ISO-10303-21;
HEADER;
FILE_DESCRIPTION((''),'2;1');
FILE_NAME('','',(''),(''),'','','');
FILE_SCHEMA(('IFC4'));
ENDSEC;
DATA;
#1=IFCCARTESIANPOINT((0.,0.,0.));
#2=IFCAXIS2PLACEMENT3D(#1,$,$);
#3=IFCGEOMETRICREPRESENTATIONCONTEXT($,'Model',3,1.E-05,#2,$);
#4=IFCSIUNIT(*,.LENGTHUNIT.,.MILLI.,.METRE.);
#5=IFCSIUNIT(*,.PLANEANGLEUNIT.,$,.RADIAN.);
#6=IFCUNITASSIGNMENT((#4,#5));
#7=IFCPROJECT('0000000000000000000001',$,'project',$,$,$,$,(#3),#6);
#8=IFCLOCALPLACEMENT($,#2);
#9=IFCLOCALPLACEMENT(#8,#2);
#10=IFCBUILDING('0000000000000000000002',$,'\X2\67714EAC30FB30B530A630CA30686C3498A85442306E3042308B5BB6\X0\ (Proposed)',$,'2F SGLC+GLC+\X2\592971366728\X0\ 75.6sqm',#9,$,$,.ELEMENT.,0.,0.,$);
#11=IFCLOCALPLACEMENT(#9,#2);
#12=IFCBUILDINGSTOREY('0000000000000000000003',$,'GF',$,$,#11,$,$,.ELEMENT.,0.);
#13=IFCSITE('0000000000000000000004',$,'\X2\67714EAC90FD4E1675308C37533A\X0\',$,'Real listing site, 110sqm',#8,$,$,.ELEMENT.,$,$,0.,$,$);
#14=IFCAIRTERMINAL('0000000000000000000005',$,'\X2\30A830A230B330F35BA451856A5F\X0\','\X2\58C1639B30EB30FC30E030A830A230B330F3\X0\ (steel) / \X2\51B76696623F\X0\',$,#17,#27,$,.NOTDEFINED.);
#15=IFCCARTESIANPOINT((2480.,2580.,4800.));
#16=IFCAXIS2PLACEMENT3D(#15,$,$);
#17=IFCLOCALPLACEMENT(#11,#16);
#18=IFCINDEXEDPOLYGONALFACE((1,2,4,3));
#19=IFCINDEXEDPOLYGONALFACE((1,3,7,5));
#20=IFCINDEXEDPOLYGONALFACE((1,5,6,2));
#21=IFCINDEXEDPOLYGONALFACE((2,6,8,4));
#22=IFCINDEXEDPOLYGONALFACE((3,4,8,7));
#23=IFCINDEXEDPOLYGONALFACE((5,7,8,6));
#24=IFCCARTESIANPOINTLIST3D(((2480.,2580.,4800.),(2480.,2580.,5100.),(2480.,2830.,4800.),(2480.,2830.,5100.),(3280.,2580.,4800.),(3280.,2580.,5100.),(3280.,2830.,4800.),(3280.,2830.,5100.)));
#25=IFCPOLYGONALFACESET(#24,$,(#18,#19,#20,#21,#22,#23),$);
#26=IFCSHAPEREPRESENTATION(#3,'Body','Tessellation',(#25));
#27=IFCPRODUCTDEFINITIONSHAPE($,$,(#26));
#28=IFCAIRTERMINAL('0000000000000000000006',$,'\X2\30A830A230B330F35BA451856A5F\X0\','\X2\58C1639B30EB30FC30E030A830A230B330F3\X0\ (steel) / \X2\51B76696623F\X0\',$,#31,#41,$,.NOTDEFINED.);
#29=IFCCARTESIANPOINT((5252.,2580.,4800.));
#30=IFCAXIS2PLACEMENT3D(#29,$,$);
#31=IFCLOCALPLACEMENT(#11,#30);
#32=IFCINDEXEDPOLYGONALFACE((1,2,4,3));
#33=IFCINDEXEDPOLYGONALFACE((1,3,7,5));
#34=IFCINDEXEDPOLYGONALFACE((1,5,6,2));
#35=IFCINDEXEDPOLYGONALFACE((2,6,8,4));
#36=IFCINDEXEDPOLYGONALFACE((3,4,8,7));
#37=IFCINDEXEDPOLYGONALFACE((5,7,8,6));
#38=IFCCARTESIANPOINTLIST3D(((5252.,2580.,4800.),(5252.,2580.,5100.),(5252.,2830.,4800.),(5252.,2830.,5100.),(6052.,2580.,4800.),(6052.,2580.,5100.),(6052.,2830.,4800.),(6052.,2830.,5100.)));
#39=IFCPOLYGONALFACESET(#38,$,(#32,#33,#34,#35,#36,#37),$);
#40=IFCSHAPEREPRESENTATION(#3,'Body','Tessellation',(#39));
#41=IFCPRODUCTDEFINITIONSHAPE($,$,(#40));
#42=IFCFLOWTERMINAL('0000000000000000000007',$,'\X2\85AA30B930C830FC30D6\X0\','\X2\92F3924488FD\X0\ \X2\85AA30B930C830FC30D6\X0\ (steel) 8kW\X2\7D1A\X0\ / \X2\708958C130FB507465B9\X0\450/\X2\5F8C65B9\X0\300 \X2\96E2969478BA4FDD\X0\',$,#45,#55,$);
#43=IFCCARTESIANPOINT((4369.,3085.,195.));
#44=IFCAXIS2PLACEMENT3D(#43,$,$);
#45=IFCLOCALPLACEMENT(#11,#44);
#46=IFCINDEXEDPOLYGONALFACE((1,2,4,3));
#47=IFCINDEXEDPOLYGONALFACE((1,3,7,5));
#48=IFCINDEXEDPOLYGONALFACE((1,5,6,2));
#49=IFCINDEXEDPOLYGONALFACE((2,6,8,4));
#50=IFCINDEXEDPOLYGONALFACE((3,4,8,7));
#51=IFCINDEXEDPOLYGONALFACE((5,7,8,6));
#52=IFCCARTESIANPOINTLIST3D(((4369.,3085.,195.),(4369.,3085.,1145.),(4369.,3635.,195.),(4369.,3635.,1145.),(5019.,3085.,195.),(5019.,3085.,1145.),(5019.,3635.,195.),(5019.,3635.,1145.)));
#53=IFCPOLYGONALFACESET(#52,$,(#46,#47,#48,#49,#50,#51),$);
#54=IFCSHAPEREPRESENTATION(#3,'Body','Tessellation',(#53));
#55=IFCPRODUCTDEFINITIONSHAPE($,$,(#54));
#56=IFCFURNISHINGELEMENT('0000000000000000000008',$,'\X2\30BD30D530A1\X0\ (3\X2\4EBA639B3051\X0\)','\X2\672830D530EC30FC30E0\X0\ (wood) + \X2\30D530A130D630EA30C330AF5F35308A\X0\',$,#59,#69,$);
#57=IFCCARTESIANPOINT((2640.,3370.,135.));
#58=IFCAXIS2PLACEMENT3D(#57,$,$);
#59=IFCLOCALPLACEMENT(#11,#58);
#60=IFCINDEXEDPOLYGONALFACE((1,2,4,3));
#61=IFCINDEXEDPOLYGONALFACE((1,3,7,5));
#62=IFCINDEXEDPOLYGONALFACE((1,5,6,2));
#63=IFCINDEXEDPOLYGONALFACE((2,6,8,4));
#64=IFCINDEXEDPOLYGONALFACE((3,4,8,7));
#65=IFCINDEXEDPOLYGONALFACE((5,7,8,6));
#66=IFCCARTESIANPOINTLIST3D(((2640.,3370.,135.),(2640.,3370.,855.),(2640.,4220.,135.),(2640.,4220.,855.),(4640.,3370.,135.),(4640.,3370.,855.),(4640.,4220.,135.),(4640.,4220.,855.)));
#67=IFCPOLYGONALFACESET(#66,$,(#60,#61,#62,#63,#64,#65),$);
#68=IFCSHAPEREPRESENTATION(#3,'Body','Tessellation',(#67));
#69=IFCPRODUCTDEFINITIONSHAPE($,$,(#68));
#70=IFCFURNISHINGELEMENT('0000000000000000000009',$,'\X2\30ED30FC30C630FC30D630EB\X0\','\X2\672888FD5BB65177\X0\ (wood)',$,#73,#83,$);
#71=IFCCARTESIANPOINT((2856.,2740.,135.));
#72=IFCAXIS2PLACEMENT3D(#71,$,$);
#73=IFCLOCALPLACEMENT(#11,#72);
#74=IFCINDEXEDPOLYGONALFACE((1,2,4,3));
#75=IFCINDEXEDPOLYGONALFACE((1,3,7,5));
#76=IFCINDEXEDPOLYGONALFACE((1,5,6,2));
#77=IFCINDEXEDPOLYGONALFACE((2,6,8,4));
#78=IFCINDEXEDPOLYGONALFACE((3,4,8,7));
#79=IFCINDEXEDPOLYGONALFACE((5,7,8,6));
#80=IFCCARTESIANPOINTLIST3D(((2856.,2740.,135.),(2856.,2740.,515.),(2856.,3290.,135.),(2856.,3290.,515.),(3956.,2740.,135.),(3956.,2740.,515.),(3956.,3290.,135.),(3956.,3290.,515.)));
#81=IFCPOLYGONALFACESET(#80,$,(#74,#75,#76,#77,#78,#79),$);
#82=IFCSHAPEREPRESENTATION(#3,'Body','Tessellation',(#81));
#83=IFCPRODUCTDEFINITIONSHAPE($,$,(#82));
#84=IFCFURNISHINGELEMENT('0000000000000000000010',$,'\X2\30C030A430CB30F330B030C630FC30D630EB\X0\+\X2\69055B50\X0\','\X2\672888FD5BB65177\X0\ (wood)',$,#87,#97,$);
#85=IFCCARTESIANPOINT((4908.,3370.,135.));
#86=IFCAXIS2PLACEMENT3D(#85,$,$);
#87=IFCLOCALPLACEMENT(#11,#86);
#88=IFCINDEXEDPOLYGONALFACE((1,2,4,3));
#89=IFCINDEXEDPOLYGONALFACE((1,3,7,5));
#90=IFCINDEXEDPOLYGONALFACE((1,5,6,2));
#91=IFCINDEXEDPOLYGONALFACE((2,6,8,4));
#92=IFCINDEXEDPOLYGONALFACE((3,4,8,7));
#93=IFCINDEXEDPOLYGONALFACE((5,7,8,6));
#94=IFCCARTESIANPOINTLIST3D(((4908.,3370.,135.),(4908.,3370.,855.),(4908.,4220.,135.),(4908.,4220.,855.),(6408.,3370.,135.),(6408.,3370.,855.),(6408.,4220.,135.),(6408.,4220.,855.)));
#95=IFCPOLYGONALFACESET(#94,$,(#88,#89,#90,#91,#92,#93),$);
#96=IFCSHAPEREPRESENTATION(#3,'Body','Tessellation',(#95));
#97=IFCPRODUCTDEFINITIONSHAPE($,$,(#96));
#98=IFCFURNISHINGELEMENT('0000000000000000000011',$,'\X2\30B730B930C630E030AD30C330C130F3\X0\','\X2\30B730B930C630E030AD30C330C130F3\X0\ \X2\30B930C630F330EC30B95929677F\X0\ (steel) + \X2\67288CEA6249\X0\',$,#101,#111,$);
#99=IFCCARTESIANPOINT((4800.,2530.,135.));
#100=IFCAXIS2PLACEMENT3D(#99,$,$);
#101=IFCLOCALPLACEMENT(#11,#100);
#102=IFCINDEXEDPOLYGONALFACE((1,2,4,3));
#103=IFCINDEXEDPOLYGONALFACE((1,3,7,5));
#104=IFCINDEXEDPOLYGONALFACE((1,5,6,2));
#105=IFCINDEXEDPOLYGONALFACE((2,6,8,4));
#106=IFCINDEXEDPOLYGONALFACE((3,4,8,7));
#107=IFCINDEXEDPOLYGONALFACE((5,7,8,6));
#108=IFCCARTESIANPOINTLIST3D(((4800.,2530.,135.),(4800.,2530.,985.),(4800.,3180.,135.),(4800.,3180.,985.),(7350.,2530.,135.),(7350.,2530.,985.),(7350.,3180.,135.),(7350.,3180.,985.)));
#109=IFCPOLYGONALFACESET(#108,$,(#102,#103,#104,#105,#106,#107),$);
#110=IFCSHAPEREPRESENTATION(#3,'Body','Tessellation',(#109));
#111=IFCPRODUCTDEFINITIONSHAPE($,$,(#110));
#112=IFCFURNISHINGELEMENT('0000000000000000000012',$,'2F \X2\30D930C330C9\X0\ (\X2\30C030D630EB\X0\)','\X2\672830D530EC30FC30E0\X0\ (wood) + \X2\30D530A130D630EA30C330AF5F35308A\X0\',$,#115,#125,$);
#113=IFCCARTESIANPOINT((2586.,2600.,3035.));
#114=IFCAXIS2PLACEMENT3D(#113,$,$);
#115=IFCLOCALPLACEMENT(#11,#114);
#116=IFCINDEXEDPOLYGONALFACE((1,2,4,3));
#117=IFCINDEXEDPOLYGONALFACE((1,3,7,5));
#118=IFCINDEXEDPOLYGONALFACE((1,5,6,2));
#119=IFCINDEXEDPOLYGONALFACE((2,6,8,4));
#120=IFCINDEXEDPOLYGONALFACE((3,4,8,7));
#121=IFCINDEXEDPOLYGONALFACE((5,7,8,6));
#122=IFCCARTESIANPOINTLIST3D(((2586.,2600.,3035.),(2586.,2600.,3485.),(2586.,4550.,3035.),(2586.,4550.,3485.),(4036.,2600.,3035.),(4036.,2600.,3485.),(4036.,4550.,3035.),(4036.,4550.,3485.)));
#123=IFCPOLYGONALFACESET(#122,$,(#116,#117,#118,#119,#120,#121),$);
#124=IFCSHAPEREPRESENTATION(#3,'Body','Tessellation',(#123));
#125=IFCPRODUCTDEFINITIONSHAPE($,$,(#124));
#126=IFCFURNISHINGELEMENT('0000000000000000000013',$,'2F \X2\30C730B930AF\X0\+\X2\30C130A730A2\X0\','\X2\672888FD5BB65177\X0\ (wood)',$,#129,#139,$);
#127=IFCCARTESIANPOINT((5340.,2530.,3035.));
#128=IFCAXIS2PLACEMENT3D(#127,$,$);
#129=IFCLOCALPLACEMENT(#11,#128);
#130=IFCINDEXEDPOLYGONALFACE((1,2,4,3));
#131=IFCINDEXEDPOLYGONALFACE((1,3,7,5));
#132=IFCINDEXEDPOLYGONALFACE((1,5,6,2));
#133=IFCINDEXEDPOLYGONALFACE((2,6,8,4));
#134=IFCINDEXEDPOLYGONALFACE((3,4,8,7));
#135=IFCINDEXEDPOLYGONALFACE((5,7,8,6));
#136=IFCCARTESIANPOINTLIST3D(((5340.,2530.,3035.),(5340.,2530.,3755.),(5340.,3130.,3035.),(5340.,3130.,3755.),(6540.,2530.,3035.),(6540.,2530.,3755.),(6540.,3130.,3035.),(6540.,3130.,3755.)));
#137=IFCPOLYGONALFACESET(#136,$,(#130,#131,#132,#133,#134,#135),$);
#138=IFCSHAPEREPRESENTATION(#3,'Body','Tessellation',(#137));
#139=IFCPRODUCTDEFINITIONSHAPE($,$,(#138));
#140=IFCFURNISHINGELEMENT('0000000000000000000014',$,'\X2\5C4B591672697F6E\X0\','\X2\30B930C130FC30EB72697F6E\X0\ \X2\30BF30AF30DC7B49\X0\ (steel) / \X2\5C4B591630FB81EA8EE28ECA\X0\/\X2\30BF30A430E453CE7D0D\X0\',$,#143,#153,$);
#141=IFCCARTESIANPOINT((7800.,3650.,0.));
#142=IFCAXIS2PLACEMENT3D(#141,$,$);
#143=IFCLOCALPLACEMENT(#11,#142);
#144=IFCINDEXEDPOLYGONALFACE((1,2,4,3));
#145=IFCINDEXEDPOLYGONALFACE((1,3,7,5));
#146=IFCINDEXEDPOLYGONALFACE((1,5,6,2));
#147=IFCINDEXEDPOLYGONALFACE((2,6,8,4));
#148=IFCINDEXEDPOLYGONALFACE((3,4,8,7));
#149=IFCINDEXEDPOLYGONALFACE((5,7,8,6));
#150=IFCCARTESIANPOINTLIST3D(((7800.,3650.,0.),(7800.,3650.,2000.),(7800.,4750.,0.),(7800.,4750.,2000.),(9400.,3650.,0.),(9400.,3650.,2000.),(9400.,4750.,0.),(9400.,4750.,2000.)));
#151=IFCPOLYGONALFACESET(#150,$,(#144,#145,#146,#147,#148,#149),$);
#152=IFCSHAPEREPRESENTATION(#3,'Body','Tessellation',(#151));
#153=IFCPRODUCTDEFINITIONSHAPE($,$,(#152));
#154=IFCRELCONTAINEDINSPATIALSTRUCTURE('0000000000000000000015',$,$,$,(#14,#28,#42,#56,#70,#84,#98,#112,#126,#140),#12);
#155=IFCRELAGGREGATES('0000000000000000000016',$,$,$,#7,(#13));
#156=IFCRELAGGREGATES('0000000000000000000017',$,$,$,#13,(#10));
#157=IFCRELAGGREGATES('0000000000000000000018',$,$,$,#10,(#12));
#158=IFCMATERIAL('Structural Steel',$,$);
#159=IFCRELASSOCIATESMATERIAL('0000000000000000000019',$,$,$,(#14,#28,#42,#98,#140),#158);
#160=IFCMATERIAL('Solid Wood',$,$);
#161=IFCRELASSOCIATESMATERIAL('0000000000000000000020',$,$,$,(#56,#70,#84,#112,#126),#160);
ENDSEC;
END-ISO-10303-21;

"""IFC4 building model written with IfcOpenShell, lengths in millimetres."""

from ifc_helpers import new_model, si_unit, frame, frame_2d, origin, place, context, project, spatial, rectangle, extrude, material, element, save


model = new_model("IFC4")

# Units and contexts
model_context = context("Model", 3, precision=1e-05, world=origin())
ifc_project = project(units=[si_unit("LENGTHUNIT", "METRE", prefix="MILLI"), si_unit("PLANEANGLEUNIT", "RADIAN")], contexts=[model_context])

# Site, building, storey
site_placement = place(None, origin())
site = spatial("IfcSite", under=ifc_project, at=site_placement, Name="東京都世田谷区", ObjectType="Real listing site, 110sqm", CompositionType="ELEMENT", RefElevation=0.0)
building_placement = place(site_placement, origin())
building = spatial("IfcBuilding", under=site, at=building_placement, Name="東京・サウナと水風呂のある家 (Proposed)", ObjectType="2F SGLC+GLC+天然木 75.6sqm", CompositionType="ELEMENT", ElevationOfRefHeight=0.0, ElevationOfTerrain=0.0)
storey_placement = place(building_placement, origin())
storey = spatial("IfcBuildingStorey", under=building, at=storey_placement, Name="GF", CompositionType="ELEMENT", Elevation=0.0)

# Shared definitions
ifc_material_1 = material(Name="Solid Wood")

# Shared definitions
ifc_material_2 = material(Name="Structural Steel")

# Air terminals
air_terminal_1_placement = place(storey_placement, frame((2480.0, 2580.0, 4800.0)))
element("IfcAirTerminal", 1, at=air_terminal_1_placement, inside=storey, material=ifc_material_2, Name="エアコン室内機", Description="壁掛ルームエアコン (steel) / 冷暖房", PredefinedType="NOTDEFINED", context=model_context, shape_type="SweptSolid", body=[
    extrude(rectangle(XDim=800.0, YDim=250.0, at=frame_2d((400.0, 125.0))), frame((2480.0, 2580.0, 4800.0)), (0.0, 0.0, 1.0), 300.0),
])
air_terminal_2_placement = place(storey_placement, frame((5252.0, 2580.0, 4800.0)))
element("IfcAirTerminal", 2, at=air_terminal_2_placement, inside=storey, material=ifc_material_2, Name="エアコン室内機", Description="壁掛ルームエアコン (steel) / 冷暖房", PredefinedType="NOTDEFINED", context=model_context, shape_type="SweptSolid", body=[
    extrude(rectangle(XDim=800.0, YDim=250.0, at=frame_2d((400.0, 125.0))), frame((5252.0, 2580.0, 4800.0)), (0.0, 0.0, 1.0), 300.0),
])

# Flow terminal
flow_terminal_1_placement = place(storey_placement, frame((4369.0, 3085.0, 195.0)))
element("IfcFlowTerminal", 3, at=flow_terminal_1_placement, inside=storey, material=ifc_material_2, Name="薪ストーブ", Description="鋳鉄製 薪ストーブ (steel) 8kW級 / 炉壁・側方450/後方300 離隔確保", context=model_context, shape_type="SweptSolid", body=[
    extrude(rectangle(XDim=650.0, YDim=550.0, at=frame_2d((325.0, 275.0))), frame((4369.0, 3085.0, 195.0)), (0.0, 0.0, 1.0), 950.0),
])

# Furnishing elements
furnishing_1_placement = place(storey_placement, frame((2640.0, 3370.0, 135.0)))
element("IfcFurnishingElement", 4, at=furnishing_1_placement, inside=storey, material=ifc_material_1, Name="ソファ (3人掛け)", Description="木フレーム (wood) + ファブリック張り", context=model_context, shape_type="SweptSolid", body=[
    extrude(rectangle(XDim=2000.0, YDim=850.0, at=frame_2d((1000.0, 425.0))), frame((2640.0, 3370.0, 135.0)), (0.0, 0.0, 1.0), 720.0),
])
furnishing_2_placement = place(storey_placement, frame((2856.0, 2740.0, 135.0)))
element("IfcFurnishingElement", 5, at=furnishing_2_placement, inside=storey, material=ifc_material_1, Name="ローテーブル", Description="木製家具 (wood)", context=model_context, shape_type="SweptSolid", body=[
    extrude(rectangle(XDim=1100.0, YDim=550.0, at=frame_2d((550.0, 275.0))), frame((2856.0, 2740.0, 135.0)), (0.0, 0.0, 1.0), 380.0),
])
furnishing_3_placement = place(storey_placement, frame((4908.0, 3370.0, 135.0)))
element("IfcFurnishingElement", 6, at=furnishing_3_placement, inside=storey, material=ifc_material_1, Name="ダイニングテーブル+椅子", Description="木製家具 (wood)", context=model_context, shape_type="SweptSolid", body=[
    extrude(rectangle(XDim=1500.0, YDim=850.0, at=frame_2d((750.0, 425.0))), frame((4908.0, 3370.0, 135.0)), (0.0, 0.0, 1.0), 720.0),
])
furnishing_4_placement = place(storey_placement, frame((4800.0, 2530.0, 135.0)))
element("IfcFurnishingElement", 7, at=furnishing_4_placement, inside=storey, material=ifc_material_2, Name="システムキッチン", Description="システムキッチン ステンレス天板 (steel) + 木質扉", context=model_context, shape_type="SweptSolid", body=[
    extrude(rectangle(XDim=2550.0, YDim=650.0, at=frame_2d((1275.0, 325.0))), frame((4800.0, 2530.0, 135.0)), (0.0, 0.0, 1.0), 850.0),
])
furnishing_5_placement = place(storey_placement, frame((2586.0, 2600.0, 3035.0)))
element("IfcFurnishingElement", 8, at=furnishing_5_placement, inside=storey, material=ifc_material_1, Name="2F ベッド (ダブル)", Description="木フレーム (wood) + ファブリック張り", context=model_context, shape_type="SweptSolid", body=[
    extrude(rectangle(XDim=1450.0, YDim=1950.0, at=frame_2d((725.0, 975.0))), frame((2586.0, 2600.0, 3035.0)), (0.0, 0.0, 1.0), 450.0),
])
furnishing_6_placement = place(storey_placement, frame((5340.0, 2530.0, 3035.0)))
element("IfcFurnishingElement", 9, at=furnishing_6_placement, inside=storey, material=ifc_material_1, Name="2F デスク+チェア", Description="木製家具 (wood)", context=model_context, shape_type="SweptSolid", body=[
    extrude(rectangle(XDim=1200.0, YDim=600.0, at=frame_2d((600.0, 300.0))), frame((5340.0, 2530.0, 3035.0)), (0.0, 0.0, 1.0), 720.0),
])
furnishing_7_placement = place(storey_placement, frame((7800.0, 3650.0, 0.0)))
element("IfcFurnishingElement", 10, at=furnishing_7_placement, inside=storey, material=ifc_material_2, Name="屋外物置", Description="スチール物置 タクボ等 (steel) / 屋外・自転車/タイヤ収納", context=model_context, shape_type="SweptSolid", body=[
    extrude(rectangle(XDim=1600.0, YDim=1100.0, at=frame_2d((800.0, 550.0))), frame((7800.0, 3650.0, 0.0)), (0.0, 0.0, 1.0), 2000.0),
])

save(model, "model.ifc")
